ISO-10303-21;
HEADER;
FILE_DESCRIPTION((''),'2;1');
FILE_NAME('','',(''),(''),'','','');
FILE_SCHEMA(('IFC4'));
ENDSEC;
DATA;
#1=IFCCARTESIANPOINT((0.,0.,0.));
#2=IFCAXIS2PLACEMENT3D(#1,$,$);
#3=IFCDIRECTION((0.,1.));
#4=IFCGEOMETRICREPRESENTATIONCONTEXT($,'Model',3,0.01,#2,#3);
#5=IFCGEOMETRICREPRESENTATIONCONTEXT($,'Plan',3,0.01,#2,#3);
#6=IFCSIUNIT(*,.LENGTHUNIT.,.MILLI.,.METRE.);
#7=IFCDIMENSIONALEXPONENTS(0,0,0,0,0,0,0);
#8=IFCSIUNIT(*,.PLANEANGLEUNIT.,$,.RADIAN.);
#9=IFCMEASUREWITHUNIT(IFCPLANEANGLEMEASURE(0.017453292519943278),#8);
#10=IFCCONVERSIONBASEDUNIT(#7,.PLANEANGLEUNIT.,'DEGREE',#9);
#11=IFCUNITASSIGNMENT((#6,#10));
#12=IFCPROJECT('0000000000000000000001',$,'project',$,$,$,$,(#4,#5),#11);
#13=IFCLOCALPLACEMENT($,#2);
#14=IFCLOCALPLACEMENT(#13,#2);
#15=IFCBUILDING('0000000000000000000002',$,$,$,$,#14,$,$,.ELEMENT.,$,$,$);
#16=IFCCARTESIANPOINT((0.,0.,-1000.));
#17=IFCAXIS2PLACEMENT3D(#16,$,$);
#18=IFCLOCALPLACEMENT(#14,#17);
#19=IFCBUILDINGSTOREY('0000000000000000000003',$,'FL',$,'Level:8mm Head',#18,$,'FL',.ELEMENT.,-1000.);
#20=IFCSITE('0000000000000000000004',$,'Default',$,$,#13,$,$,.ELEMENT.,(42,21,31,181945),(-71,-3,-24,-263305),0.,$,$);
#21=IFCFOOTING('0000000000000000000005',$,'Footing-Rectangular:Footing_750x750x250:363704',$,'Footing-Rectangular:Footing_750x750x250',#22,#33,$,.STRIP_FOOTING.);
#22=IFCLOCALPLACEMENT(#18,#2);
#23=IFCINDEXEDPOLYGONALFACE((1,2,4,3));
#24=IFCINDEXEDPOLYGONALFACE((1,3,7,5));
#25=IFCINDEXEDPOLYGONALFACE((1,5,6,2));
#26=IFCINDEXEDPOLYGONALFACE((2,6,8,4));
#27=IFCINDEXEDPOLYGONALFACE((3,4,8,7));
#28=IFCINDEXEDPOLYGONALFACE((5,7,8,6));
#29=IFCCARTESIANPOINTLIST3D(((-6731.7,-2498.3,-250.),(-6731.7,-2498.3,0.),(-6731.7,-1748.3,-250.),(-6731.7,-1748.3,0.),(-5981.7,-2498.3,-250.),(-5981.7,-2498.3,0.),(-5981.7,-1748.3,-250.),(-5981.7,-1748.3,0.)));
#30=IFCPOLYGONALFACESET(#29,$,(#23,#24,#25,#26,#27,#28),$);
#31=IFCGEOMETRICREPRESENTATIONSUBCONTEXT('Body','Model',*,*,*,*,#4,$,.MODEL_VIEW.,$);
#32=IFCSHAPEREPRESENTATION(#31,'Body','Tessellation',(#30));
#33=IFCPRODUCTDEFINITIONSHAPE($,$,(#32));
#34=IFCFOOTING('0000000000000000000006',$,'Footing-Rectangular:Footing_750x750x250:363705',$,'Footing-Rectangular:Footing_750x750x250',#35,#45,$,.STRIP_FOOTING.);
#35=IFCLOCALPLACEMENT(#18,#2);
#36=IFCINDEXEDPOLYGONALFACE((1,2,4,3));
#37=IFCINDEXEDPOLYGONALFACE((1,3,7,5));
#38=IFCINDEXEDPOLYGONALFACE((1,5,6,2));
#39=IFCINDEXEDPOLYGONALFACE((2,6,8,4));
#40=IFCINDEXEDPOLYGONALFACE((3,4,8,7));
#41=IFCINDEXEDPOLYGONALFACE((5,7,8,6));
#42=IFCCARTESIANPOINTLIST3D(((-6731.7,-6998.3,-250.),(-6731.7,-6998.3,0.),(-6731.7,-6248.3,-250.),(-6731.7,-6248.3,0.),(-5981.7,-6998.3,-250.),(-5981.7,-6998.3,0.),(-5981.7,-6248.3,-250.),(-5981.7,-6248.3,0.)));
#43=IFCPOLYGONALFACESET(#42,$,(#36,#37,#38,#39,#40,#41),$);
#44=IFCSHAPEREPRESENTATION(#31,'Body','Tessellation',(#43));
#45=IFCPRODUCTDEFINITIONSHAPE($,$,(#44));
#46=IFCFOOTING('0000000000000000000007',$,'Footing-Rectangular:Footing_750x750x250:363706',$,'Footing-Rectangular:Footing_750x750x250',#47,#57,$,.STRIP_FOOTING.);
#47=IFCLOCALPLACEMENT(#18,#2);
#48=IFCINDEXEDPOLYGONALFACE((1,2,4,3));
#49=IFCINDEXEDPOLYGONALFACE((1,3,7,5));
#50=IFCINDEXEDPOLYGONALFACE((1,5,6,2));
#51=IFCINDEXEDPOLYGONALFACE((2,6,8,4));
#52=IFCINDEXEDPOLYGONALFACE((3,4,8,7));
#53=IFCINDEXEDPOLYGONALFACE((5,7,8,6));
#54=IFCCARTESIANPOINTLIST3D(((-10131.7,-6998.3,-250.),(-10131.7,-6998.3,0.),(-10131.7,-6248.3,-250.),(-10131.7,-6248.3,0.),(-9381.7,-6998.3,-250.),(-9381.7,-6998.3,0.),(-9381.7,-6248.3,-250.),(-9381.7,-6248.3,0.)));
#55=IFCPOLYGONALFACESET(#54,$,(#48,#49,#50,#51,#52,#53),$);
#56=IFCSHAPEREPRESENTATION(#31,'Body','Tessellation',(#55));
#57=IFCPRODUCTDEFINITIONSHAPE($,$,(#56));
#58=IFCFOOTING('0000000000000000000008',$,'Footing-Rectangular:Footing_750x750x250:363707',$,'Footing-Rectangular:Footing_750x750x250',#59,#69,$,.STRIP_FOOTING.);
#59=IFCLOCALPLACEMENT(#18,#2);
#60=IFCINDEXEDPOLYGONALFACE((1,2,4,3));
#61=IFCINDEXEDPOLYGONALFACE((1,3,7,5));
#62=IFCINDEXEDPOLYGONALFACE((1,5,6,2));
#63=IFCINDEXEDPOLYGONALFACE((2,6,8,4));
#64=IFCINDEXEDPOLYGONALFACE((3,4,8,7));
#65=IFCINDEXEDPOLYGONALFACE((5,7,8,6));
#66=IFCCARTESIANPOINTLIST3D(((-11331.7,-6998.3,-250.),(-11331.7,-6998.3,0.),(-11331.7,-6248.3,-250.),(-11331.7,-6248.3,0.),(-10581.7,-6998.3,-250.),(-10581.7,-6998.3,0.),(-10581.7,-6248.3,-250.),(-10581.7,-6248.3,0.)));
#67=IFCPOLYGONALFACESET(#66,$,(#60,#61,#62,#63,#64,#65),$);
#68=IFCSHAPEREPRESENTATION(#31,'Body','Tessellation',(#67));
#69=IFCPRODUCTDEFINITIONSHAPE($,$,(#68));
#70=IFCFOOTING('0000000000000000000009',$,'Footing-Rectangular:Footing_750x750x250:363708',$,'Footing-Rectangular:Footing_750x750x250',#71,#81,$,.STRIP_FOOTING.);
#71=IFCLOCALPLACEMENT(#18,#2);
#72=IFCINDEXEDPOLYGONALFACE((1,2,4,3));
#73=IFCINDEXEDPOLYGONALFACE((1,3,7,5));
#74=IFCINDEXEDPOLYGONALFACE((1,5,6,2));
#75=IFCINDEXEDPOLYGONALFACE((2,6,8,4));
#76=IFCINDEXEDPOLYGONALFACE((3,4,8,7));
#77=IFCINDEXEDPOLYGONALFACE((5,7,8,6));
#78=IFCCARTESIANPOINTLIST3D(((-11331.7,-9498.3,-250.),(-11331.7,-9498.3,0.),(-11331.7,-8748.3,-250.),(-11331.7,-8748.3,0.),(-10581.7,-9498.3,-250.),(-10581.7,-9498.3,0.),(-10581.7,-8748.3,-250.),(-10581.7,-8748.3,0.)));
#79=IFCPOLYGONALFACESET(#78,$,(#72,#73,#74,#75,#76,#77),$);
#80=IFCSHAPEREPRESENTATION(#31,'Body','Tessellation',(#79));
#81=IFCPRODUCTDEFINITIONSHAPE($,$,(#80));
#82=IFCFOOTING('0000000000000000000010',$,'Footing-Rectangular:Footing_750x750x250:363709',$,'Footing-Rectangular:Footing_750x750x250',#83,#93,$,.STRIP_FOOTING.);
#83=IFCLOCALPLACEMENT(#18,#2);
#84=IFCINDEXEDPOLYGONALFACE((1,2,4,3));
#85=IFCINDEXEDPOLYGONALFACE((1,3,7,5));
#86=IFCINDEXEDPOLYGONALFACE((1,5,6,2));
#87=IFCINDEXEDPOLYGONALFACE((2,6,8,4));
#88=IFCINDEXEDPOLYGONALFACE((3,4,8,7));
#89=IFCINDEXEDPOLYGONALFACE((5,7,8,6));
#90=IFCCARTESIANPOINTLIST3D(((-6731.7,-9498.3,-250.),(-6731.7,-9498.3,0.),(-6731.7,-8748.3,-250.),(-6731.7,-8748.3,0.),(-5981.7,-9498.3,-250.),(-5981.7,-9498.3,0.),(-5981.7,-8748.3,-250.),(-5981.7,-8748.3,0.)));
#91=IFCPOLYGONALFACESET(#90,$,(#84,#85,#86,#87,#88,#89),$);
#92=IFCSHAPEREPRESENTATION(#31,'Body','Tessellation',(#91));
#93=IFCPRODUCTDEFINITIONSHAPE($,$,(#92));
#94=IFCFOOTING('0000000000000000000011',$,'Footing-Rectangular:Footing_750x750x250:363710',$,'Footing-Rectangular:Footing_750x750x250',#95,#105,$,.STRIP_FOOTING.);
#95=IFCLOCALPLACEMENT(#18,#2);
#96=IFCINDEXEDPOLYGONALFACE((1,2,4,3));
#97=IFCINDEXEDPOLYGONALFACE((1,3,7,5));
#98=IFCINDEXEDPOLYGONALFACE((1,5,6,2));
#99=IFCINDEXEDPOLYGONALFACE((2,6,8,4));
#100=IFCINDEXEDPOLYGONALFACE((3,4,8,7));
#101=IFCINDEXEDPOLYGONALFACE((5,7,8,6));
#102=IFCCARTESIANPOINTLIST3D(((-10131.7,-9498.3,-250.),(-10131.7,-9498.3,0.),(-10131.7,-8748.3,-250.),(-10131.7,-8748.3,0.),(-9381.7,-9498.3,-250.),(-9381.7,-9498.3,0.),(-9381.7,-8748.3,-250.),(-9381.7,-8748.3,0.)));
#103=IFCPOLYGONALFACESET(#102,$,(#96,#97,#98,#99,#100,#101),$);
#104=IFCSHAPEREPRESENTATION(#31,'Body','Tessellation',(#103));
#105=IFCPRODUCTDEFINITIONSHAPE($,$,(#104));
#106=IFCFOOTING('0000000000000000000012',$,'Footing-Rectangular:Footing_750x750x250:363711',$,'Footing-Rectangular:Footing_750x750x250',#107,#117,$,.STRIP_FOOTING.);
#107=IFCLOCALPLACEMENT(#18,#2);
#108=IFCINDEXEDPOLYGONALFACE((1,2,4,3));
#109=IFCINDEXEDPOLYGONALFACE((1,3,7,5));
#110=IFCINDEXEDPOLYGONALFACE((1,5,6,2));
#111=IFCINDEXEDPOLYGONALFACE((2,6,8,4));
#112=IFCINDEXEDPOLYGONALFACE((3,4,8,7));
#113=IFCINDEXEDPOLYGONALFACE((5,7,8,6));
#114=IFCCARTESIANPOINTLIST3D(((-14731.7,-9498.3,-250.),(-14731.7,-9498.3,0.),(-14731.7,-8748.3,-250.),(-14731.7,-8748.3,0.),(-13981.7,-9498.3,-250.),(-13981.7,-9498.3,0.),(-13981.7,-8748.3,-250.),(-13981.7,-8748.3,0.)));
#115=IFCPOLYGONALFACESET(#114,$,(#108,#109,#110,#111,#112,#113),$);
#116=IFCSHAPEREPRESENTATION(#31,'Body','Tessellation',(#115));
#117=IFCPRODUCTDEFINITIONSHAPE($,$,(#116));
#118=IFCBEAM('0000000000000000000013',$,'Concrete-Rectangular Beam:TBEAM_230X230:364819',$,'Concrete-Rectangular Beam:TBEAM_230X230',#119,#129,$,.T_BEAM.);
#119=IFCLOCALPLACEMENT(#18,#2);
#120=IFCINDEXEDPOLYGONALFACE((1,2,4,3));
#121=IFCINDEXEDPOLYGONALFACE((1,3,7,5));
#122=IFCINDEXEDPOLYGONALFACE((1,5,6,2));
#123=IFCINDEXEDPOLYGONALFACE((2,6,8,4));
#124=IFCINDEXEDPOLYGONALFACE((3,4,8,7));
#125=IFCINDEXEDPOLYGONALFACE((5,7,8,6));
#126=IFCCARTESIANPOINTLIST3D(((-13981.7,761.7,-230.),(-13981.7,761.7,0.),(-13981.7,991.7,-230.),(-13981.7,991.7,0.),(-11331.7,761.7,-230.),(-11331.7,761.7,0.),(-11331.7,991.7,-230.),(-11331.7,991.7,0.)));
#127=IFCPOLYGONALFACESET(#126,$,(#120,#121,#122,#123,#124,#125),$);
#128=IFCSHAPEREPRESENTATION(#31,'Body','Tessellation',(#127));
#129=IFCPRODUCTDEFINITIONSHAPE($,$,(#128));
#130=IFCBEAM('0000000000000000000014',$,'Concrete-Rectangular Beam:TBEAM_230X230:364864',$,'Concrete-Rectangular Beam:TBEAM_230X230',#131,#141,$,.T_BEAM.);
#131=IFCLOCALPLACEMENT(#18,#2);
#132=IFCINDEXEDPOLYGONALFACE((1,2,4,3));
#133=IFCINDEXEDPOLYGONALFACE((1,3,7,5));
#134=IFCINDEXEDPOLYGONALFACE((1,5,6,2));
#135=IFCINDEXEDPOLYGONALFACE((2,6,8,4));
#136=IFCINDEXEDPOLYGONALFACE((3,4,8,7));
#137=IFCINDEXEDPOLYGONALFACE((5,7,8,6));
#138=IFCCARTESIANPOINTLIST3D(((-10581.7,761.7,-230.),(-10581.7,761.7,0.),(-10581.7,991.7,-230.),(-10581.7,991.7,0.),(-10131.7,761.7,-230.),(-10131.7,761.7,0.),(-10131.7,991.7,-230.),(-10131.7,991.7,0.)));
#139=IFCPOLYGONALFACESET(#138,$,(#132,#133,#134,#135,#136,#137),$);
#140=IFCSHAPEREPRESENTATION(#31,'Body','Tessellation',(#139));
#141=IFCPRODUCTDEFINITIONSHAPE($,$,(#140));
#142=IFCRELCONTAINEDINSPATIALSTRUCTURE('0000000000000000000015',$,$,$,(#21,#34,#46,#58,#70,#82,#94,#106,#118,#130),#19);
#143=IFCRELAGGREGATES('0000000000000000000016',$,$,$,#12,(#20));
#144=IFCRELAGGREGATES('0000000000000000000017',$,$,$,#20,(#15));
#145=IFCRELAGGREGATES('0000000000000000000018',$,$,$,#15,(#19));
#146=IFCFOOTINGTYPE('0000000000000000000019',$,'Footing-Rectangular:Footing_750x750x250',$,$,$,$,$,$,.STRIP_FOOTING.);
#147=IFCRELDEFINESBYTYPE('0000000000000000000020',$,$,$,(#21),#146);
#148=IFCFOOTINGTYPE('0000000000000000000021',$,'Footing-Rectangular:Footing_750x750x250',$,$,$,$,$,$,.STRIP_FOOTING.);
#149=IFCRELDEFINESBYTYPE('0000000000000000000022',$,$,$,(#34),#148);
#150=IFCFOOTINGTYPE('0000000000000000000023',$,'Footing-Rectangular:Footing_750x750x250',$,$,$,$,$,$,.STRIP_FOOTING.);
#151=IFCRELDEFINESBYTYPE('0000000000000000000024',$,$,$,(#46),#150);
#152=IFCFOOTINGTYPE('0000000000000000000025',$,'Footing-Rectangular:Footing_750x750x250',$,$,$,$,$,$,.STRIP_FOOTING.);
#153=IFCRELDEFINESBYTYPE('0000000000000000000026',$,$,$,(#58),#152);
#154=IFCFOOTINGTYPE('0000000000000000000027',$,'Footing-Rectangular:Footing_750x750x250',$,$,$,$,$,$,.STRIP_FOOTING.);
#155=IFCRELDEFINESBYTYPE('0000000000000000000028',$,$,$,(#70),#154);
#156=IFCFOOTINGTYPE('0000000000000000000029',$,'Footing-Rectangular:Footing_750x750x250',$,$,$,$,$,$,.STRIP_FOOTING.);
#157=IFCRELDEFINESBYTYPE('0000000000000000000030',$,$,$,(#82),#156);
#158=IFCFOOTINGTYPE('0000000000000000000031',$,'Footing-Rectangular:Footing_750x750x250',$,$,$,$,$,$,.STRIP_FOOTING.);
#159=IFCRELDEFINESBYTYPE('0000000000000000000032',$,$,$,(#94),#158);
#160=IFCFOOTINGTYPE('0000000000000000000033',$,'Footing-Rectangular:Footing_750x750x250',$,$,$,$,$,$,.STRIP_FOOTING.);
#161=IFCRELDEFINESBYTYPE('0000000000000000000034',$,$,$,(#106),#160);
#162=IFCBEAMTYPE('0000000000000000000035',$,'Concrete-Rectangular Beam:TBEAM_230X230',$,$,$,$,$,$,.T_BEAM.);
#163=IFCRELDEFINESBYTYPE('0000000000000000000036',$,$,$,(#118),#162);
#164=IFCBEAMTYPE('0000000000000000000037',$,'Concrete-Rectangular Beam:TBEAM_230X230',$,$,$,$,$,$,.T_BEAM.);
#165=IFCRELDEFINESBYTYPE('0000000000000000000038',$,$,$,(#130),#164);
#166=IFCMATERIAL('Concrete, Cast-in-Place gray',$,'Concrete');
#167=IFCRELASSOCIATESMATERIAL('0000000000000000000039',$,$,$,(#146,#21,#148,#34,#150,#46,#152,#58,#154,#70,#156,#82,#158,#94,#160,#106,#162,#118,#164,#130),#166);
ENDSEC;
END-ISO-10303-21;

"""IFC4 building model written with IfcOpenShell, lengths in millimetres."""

from ifc_helpers import new_model, entity, si_unit, converted_unit, direction, frame, origin, place, context, subcontext, project, spatial, indexed_curve, outline, extrude, source, transform, mapped, material, type_object, type_shapes, element, save


model = new_model("IFC4")

# Units and contexts
model_context = context("Model", 3, precision=0.01, world=origin(), true_north=direction((0.0, 1.0)))
plan_context = context("Plan", 3, precision=0.01, world=origin(), true_north=direction((0.0, 1.0)))
body_context = subcontext(model_context, "Body", "Model", "MODEL_VIEW")
ifc_project = project(units=[si_unit("LENGTHUNIT", "METRE", prefix="MILLI"), converted_unit("PLANEANGLEUNIT", "DEGREE", entity("IfcPlaneAngleMeasure", 0.017453292519943278), si_unit("PLANEANGLEUNIT", "RADIAN"), dimensions=[0, 0, 0, 0, 0, 0, 0])], contexts=[model_context, plan_context])

# Site, building, storey
site_placement = place(None, origin())
site = spatial("IfcSite", under=ifc_project, at=site_placement, Name="Default", CompositionType="ELEMENT", RefLatitude=(42, 21, 31, 181945), RefLongitude=(-71, -3, -24, -263305), RefElevation=0.0)
building_placement = place(site_placement, origin())
building = spatial("IfcBuilding", under=site, at=building_placement, CompositionType="ELEMENT")
storey_placement = place(building_placement, frame((0.0, 0.0, -1000.0)))
storey = spatial("IfcBuildingStorey", under=building, at=storey_placement, Name="FL", ObjectType="Level:8mm Head", LongName="FL", CompositionType="ELEMENT", Elevation=-1000.0)

# Footings
ifc_material = material(Name="Concrete, Cast-in-Place gray", Category="Concrete")
footing_type_1 = type_object("IfcFootingType", Name="Footing-Rectangular:Footing_750x750x250", PredefinedType="STRIP_FOOTING", material=ifc_material)
shared_shape_1 = source(origin(), body_context, "Body", "SweptSolid", [
    extrude(outline(indexed_curve([(-375.0, -375.0), (375.0, -375.0), (375.0, 375.0), (-375.0, 375.0), (-375.0, -375.0)], self_intersect=False)), frame((-6356.7, -2123.3, -1250.0), z_axis=(0.0, 0.0, 1.0), x_axis=(-1.0, 0.0, 0.0)), (0.0, 0.0, 1.0), 250.0),
])
type_shapes(footing_type_1, [shared_shape_1])
footing_1_placement = place(storey_placement, frame((0.0, 0.0, 1000.0)))
element("IfcFooting", 1, at=footing_1_placement, inside=storey, type_object=footing_type_1, material=ifc_material, Name="Footing-Rectangular:Footing_750x750x250:363704", ObjectType="Footing-Rectangular:Footing_750x750x250", PredefinedType="STRIP_FOOTING", context=body_context, shape_type="MappedRepresentation", body=[
    mapped(shared_shape_1, transform((0.0, 0.0, 0.0), scale=1.0)),
])
footing_type_2 = type_object("IfcFootingType", Name="Footing-Rectangular:Footing_750x750x250", PredefinedType="STRIP_FOOTING", material=ifc_material)
shared_shape_2 = source(origin(), body_context, "Body", "SweptSolid", [
    extrude(outline(indexed_curve([(-375.0, -375.0), (375.0, -375.0), (375.0, 375.0), (-375.0, 375.0), (-375.0, -375.0)], self_intersect=False)), frame((-6356.7, -6623.3, -1250.0), z_axis=(0.0, 0.0, 1.0), x_axis=(-1.0, 0.0, 0.0)), (0.0, 0.0, 1.0), 250.0),
])
type_shapes(footing_type_2, [shared_shape_2])
footing_2_placement = place(storey_placement, frame((0.0, 0.0, 1000.0)))
element("IfcFooting", 2, at=footing_2_placement, inside=storey, type_object=footing_type_2, material=ifc_material, Name="Footing-Rectangular:Footing_750x750x250:363705", ObjectType="Footing-Rectangular:Footing_750x750x250", PredefinedType="STRIP_FOOTING", context=body_context, shape_type="MappedRepresentation", body=[
    mapped(shared_shape_2, transform((0.0, 0.0, 0.0), scale=1.0)),
])
footing_type_3 = type_object("IfcFootingType", Name="Footing-Rectangular:Footing_750x750x250", PredefinedType="STRIP_FOOTING", material=ifc_material)
shared_shape_3 = source(origin(), body_context, "Body", "SweptSolid", [
    extrude(outline(indexed_curve([(-375.0, -375.0), (375.0, -375.0), (375.0, 375.0), (-375.0, 375.0), (-375.0, -375.0)], self_intersect=False)), frame((-9756.7, -6623.3, -1250.0), z_axis=(0.0, 0.0, 1.0), x_axis=(-1.0, 0.0, 0.0)), (0.0, 0.0, 1.0), 250.0),
])
type_shapes(footing_type_3, [shared_shape_3])
footing_3_placement = place(storey_placement, frame((0.0, 0.0, 1000.0)))
element("IfcFooting", 3, at=footing_3_placement, inside=storey, type_object=footing_type_3, material=ifc_material, Name="Footing-Rectangular:Footing_750x750x250:363706", ObjectType="Footing-Rectangular:Footing_750x750x250", PredefinedType="STRIP_FOOTING", context=body_context, shape_type="MappedRepresentation", body=[
    mapped(shared_shape_3, transform((0.0, 0.0, 0.0), scale=1.0)),
])
footing_type_4 = type_object("IfcFootingType", Name="Footing-Rectangular:Footing_750x750x250", PredefinedType="STRIP_FOOTING", material=ifc_material)
shared_shape_4 = source(origin(), body_context, "Body", "SweptSolid", [
    extrude(outline(indexed_curve([(-375.0, -375.0), (375.0, -375.0), (375.0, 375.0), (-375.0, 375.0), (-375.0, -375.0)], self_intersect=False)), frame((-10956.7, -6623.3, -1250.0), z_axis=(0.0, 0.0, 1.0), x_axis=(0.0, -1.0, 0.0)), (0.0, 0.0, 1.0), 250.0),
])
type_shapes(footing_type_4, [shared_shape_4])
footing_4_placement = place(storey_placement, frame((0.0, 0.0, 1000.0)))
element("IfcFooting", 4, at=footing_4_placement, inside=storey, type_object=footing_type_4, material=ifc_material, Name="Footing-Rectangular:Footing_750x750x250:363707", ObjectType="Footing-Rectangular:Footing_750x750x250", PredefinedType="STRIP_FOOTING", context=body_context, shape_type="MappedRepresentation", body=[
    mapped(shared_shape_4, transform((0.0, 0.0, 0.0), scale=1.0)),
])
footing_type_5 = type_object("IfcFootingType", Name="Footing-Rectangular:Footing_750x750x250", PredefinedType="STRIP_FOOTING", material=ifc_material)
shared_shape_5 = source(origin(), body_context, "Body", "SweptSolid", [
    extrude(outline(indexed_curve([(-375.0, -375.0), (375.0, -375.0), (375.0, 375.0), (-375.0, 375.0), (-375.0, -375.0)], self_intersect=False)), frame((-10956.7, -9123.3, -1250.0), z_axis=(0.0, 0.0, 1.0), x_axis=(0.0, -1.0, 0.0)), (0.0, 0.0, 1.0), 250.0),
])
type_shapes(footing_type_5, [shared_shape_5])
footing_5_placement = place(storey_placement, frame((0.0, 0.0, 1000.0)))
element("IfcFooting", 5, at=footing_5_placement, inside=storey, type_object=footing_type_5, material=ifc_material, Name="Footing-Rectangular:Footing_750x750x250:363708", ObjectType="Footing-Rectangular:Footing_750x750x250", PredefinedType="STRIP_FOOTING", context=body_context, shape_type="MappedRepresentation", body=[
    mapped(shared_shape_5, transform((0.0, 0.0, 0.0), scale=1.0)),
])
footing_type_6 = type_object("IfcFootingType", Name="Footing-Rectangular:Footing_750x750x250", PredefinedType="STRIP_FOOTING", material=ifc_material)
shared_shape_6 = source(origin(), body_context, "Body", "SweptSolid", [
    extrude(outline(indexed_curve([(-375.0, -375.0), (375.0, -375.0), (375.0, 375.0), (-375.0, 375.0), (-375.0, -375.0)], self_intersect=False)), frame((-6356.7, -9123.3, -1250.0), z_axis=(0.0, 0.0, 1.0), x_axis=(0.0, -1.0, 0.0)), (0.0, 0.0, 1.0), 250.0),
])
type_shapes(footing_type_6, [shared_shape_6])
footing_6_placement = place(storey_placement, frame((0.0, 0.0, 1000.0)))
element("IfcFooting", 6, at=footing_6_placement, inside=storey, type_object=footing_type_6, material=ifc_material, Name="Footing-Rectangular:Footing_750x750x250:363709", ObjectType="Footing-Rectangular:Footing_750x750x250", PredefinedType="STRIP_FOOTING", context=body_context, shape_type="MappedRepresentation", body=[
    mapped(shared_shape_6, transform((0.0, 0.0, 0.0), scale=1.0)),
])
footing_type_7 = type_object("IfcFootingType", Name="Footing-Rectangular:Footing_750x750x250", PredefinedType="STRIP_FOOTING", material=ifc_material)
shared_shape_7 = source(origin(), body_context, "Body", "SweptSolid", [
    extrude(outline(indexed_curve([(-375.0, -375.0), (375.0, -375.0), (375.0, 375.0), (-375.0, 375.0), (-375.0, -375.0)], self_intersect=False)), frame((-9756.7, -9123.3, -1250.0), z_axis=(0.0, 0.0, 1.0), x_axis=(0.0, -1.0, 0.0)), (0.0, 0.0, 1.0), 250.0),
])
type_shapes(footing_type_7, [shared_shape_7])
footing_7_placement = place(storey_placement, frame((0.0, 0.0, 1000.0)))
element("IfcFooting", 7, at=footing_7_placement, inside=storey, type_object=footing_type_7, material=ifc_material, Name="Footing-Rectangular:Footing_750x750x250:363710", ObjectType="Footing-Rectangular:Footing_750x750x250", PredefinedType="STRIP_FOOTING", context=body_context, shape_type="MappedRepresentation", body=[
    mapped(shared_shape_7, transform((0.0, 0.0, 0.0), scale=1.0)),
])
footing_type_8 = type_object("IfcFootingType", Name="Footing-Rectangular:Footing_750x750x250", PredefinedType="STRIP_FOOTING", material=ifc_material)
shared_shape_8 = source(origin(), body_context, "Body", "SweptSolid", [
    extrude(outline(indexed_curve([(-375.0, -375.0), (375.0, -375.0), (375.0, 375.0), (-375.0, 375.0), (-375.0, -375.0)], self_intersect=False)), frame((-14356.7, -9123.3, -1250.0), z_axis=(0.0, 0.0, 1.0), x_axis=(-1.0, 0.0, 0.0)), (0.0, 0.0, 1.0), 250.0),
])
type_shapes(footing_type_8, [shared_shape_8])
footing_8_placement = place(storey_placement, frame((0.0, 0.0, 1000.0)))
element("IfcFooting", 8, at=footing_8_placement, inside=storey, type_object=footing_type_8, material=ifc_material, Name="Footing-Rectangular:Footing_750x750x250:363711", ObjectType="Footing-Rectangular:Footing_750x750x250", PredefinedType="STRIP_FOOTING", context=body_context, shape_type="MappedRepresentation", body=[
    mapped(shared_shape_8, transform((0.0, 0.0, 0.0), scale=1.0)),
])

# Beams
beam_type_1 = type_object("IfcBeamType", Name="Concrete-Rectangular Beam:TBEAM_230X230", PredefinedType="T_BEAM", material=ifc_material)
shared_shape_9 = source(origin(), body_context, "Body", "SweptSolid", [
    extrude(outline(indexed_curve([(-115.0, -115.0), (115.0, -115.0), (115.0, 115.0), (-115.0, 115.0), (-115.0, -115.0)], self_intersect=False)), frame((-13981.7, 876.7, -1115.0), z_axis=(1.0, 0.0, 0.0), x_axis=(0.0, 0.0, -1.0)), (0.0, 0.0, 1.0), 2650.0),
])
type_shapes(beam_type_1, [shared_shape_9])
beam_1_placement = place(storey_placement, frame((0.0, 0.0, 1000.0)))
element("IfcBeam", 9, at=beam_1_placement, inside=storey, type_object=beam_type_1, material=ifc_material, Name="Concrete-Rectangular Beam:TBEAM_230X230:364819", ObjectType="Concrete-Rectangular Beam:TBEAM_230X230", PredefinedType="T_BEAM", context=body_context, shape_type="MappedRepresentation", body=[
    mapped(shared_shape_9, transform((0.0, 0.0, 0.0), scale=1.0)),
])
beam_type_2 = type_object("IfcBeamType", Name="Concrete-Rectangular Beam:TBEAM_230X230", PredefinedType="T_BEAM", material=ifc_material)
shared_shape_10 = source(origin(), body_context, "Body", "SweptSolid", [
    extrude(outline(indexed_curve([(-115.0, -115.0), (115.0, -115.0), (115.0, 115.0), (-115.0, 115.0), (-115.0, -115.0)], self_intersect=False)), frame((-10131.7, 876.7, -1115.0), z_axis=(-1.0, 0.0, 0.0), x_axis=(0.0, 0.0, -1.0)), (0.0, 0.0, 1.0), 450.0),
])
type_shapes(beam_type_2, [shared_shape_10])
beam_2_placement = place(storey_placement, frame((0.0, 0.0, 1000.0)))
element("IfcBeam", 10, at=beam_2_placement, inside=storey, type_object=beam_type_2, material=ifc_material, Name="Concrete-Rectangular Beam:TBEAM_230X230:364864", ObjectType="Concrete-Rectangular Beam:TBEAM_230X230", PredefinedType="T_BEAM", context=body_context, shape_type="MappedRepresentation", body=[
    mapped(shared_shape_10, transform((0.0, 0.0, 0.0), scale=1.0)),
])

save(model, "model.ifc")
